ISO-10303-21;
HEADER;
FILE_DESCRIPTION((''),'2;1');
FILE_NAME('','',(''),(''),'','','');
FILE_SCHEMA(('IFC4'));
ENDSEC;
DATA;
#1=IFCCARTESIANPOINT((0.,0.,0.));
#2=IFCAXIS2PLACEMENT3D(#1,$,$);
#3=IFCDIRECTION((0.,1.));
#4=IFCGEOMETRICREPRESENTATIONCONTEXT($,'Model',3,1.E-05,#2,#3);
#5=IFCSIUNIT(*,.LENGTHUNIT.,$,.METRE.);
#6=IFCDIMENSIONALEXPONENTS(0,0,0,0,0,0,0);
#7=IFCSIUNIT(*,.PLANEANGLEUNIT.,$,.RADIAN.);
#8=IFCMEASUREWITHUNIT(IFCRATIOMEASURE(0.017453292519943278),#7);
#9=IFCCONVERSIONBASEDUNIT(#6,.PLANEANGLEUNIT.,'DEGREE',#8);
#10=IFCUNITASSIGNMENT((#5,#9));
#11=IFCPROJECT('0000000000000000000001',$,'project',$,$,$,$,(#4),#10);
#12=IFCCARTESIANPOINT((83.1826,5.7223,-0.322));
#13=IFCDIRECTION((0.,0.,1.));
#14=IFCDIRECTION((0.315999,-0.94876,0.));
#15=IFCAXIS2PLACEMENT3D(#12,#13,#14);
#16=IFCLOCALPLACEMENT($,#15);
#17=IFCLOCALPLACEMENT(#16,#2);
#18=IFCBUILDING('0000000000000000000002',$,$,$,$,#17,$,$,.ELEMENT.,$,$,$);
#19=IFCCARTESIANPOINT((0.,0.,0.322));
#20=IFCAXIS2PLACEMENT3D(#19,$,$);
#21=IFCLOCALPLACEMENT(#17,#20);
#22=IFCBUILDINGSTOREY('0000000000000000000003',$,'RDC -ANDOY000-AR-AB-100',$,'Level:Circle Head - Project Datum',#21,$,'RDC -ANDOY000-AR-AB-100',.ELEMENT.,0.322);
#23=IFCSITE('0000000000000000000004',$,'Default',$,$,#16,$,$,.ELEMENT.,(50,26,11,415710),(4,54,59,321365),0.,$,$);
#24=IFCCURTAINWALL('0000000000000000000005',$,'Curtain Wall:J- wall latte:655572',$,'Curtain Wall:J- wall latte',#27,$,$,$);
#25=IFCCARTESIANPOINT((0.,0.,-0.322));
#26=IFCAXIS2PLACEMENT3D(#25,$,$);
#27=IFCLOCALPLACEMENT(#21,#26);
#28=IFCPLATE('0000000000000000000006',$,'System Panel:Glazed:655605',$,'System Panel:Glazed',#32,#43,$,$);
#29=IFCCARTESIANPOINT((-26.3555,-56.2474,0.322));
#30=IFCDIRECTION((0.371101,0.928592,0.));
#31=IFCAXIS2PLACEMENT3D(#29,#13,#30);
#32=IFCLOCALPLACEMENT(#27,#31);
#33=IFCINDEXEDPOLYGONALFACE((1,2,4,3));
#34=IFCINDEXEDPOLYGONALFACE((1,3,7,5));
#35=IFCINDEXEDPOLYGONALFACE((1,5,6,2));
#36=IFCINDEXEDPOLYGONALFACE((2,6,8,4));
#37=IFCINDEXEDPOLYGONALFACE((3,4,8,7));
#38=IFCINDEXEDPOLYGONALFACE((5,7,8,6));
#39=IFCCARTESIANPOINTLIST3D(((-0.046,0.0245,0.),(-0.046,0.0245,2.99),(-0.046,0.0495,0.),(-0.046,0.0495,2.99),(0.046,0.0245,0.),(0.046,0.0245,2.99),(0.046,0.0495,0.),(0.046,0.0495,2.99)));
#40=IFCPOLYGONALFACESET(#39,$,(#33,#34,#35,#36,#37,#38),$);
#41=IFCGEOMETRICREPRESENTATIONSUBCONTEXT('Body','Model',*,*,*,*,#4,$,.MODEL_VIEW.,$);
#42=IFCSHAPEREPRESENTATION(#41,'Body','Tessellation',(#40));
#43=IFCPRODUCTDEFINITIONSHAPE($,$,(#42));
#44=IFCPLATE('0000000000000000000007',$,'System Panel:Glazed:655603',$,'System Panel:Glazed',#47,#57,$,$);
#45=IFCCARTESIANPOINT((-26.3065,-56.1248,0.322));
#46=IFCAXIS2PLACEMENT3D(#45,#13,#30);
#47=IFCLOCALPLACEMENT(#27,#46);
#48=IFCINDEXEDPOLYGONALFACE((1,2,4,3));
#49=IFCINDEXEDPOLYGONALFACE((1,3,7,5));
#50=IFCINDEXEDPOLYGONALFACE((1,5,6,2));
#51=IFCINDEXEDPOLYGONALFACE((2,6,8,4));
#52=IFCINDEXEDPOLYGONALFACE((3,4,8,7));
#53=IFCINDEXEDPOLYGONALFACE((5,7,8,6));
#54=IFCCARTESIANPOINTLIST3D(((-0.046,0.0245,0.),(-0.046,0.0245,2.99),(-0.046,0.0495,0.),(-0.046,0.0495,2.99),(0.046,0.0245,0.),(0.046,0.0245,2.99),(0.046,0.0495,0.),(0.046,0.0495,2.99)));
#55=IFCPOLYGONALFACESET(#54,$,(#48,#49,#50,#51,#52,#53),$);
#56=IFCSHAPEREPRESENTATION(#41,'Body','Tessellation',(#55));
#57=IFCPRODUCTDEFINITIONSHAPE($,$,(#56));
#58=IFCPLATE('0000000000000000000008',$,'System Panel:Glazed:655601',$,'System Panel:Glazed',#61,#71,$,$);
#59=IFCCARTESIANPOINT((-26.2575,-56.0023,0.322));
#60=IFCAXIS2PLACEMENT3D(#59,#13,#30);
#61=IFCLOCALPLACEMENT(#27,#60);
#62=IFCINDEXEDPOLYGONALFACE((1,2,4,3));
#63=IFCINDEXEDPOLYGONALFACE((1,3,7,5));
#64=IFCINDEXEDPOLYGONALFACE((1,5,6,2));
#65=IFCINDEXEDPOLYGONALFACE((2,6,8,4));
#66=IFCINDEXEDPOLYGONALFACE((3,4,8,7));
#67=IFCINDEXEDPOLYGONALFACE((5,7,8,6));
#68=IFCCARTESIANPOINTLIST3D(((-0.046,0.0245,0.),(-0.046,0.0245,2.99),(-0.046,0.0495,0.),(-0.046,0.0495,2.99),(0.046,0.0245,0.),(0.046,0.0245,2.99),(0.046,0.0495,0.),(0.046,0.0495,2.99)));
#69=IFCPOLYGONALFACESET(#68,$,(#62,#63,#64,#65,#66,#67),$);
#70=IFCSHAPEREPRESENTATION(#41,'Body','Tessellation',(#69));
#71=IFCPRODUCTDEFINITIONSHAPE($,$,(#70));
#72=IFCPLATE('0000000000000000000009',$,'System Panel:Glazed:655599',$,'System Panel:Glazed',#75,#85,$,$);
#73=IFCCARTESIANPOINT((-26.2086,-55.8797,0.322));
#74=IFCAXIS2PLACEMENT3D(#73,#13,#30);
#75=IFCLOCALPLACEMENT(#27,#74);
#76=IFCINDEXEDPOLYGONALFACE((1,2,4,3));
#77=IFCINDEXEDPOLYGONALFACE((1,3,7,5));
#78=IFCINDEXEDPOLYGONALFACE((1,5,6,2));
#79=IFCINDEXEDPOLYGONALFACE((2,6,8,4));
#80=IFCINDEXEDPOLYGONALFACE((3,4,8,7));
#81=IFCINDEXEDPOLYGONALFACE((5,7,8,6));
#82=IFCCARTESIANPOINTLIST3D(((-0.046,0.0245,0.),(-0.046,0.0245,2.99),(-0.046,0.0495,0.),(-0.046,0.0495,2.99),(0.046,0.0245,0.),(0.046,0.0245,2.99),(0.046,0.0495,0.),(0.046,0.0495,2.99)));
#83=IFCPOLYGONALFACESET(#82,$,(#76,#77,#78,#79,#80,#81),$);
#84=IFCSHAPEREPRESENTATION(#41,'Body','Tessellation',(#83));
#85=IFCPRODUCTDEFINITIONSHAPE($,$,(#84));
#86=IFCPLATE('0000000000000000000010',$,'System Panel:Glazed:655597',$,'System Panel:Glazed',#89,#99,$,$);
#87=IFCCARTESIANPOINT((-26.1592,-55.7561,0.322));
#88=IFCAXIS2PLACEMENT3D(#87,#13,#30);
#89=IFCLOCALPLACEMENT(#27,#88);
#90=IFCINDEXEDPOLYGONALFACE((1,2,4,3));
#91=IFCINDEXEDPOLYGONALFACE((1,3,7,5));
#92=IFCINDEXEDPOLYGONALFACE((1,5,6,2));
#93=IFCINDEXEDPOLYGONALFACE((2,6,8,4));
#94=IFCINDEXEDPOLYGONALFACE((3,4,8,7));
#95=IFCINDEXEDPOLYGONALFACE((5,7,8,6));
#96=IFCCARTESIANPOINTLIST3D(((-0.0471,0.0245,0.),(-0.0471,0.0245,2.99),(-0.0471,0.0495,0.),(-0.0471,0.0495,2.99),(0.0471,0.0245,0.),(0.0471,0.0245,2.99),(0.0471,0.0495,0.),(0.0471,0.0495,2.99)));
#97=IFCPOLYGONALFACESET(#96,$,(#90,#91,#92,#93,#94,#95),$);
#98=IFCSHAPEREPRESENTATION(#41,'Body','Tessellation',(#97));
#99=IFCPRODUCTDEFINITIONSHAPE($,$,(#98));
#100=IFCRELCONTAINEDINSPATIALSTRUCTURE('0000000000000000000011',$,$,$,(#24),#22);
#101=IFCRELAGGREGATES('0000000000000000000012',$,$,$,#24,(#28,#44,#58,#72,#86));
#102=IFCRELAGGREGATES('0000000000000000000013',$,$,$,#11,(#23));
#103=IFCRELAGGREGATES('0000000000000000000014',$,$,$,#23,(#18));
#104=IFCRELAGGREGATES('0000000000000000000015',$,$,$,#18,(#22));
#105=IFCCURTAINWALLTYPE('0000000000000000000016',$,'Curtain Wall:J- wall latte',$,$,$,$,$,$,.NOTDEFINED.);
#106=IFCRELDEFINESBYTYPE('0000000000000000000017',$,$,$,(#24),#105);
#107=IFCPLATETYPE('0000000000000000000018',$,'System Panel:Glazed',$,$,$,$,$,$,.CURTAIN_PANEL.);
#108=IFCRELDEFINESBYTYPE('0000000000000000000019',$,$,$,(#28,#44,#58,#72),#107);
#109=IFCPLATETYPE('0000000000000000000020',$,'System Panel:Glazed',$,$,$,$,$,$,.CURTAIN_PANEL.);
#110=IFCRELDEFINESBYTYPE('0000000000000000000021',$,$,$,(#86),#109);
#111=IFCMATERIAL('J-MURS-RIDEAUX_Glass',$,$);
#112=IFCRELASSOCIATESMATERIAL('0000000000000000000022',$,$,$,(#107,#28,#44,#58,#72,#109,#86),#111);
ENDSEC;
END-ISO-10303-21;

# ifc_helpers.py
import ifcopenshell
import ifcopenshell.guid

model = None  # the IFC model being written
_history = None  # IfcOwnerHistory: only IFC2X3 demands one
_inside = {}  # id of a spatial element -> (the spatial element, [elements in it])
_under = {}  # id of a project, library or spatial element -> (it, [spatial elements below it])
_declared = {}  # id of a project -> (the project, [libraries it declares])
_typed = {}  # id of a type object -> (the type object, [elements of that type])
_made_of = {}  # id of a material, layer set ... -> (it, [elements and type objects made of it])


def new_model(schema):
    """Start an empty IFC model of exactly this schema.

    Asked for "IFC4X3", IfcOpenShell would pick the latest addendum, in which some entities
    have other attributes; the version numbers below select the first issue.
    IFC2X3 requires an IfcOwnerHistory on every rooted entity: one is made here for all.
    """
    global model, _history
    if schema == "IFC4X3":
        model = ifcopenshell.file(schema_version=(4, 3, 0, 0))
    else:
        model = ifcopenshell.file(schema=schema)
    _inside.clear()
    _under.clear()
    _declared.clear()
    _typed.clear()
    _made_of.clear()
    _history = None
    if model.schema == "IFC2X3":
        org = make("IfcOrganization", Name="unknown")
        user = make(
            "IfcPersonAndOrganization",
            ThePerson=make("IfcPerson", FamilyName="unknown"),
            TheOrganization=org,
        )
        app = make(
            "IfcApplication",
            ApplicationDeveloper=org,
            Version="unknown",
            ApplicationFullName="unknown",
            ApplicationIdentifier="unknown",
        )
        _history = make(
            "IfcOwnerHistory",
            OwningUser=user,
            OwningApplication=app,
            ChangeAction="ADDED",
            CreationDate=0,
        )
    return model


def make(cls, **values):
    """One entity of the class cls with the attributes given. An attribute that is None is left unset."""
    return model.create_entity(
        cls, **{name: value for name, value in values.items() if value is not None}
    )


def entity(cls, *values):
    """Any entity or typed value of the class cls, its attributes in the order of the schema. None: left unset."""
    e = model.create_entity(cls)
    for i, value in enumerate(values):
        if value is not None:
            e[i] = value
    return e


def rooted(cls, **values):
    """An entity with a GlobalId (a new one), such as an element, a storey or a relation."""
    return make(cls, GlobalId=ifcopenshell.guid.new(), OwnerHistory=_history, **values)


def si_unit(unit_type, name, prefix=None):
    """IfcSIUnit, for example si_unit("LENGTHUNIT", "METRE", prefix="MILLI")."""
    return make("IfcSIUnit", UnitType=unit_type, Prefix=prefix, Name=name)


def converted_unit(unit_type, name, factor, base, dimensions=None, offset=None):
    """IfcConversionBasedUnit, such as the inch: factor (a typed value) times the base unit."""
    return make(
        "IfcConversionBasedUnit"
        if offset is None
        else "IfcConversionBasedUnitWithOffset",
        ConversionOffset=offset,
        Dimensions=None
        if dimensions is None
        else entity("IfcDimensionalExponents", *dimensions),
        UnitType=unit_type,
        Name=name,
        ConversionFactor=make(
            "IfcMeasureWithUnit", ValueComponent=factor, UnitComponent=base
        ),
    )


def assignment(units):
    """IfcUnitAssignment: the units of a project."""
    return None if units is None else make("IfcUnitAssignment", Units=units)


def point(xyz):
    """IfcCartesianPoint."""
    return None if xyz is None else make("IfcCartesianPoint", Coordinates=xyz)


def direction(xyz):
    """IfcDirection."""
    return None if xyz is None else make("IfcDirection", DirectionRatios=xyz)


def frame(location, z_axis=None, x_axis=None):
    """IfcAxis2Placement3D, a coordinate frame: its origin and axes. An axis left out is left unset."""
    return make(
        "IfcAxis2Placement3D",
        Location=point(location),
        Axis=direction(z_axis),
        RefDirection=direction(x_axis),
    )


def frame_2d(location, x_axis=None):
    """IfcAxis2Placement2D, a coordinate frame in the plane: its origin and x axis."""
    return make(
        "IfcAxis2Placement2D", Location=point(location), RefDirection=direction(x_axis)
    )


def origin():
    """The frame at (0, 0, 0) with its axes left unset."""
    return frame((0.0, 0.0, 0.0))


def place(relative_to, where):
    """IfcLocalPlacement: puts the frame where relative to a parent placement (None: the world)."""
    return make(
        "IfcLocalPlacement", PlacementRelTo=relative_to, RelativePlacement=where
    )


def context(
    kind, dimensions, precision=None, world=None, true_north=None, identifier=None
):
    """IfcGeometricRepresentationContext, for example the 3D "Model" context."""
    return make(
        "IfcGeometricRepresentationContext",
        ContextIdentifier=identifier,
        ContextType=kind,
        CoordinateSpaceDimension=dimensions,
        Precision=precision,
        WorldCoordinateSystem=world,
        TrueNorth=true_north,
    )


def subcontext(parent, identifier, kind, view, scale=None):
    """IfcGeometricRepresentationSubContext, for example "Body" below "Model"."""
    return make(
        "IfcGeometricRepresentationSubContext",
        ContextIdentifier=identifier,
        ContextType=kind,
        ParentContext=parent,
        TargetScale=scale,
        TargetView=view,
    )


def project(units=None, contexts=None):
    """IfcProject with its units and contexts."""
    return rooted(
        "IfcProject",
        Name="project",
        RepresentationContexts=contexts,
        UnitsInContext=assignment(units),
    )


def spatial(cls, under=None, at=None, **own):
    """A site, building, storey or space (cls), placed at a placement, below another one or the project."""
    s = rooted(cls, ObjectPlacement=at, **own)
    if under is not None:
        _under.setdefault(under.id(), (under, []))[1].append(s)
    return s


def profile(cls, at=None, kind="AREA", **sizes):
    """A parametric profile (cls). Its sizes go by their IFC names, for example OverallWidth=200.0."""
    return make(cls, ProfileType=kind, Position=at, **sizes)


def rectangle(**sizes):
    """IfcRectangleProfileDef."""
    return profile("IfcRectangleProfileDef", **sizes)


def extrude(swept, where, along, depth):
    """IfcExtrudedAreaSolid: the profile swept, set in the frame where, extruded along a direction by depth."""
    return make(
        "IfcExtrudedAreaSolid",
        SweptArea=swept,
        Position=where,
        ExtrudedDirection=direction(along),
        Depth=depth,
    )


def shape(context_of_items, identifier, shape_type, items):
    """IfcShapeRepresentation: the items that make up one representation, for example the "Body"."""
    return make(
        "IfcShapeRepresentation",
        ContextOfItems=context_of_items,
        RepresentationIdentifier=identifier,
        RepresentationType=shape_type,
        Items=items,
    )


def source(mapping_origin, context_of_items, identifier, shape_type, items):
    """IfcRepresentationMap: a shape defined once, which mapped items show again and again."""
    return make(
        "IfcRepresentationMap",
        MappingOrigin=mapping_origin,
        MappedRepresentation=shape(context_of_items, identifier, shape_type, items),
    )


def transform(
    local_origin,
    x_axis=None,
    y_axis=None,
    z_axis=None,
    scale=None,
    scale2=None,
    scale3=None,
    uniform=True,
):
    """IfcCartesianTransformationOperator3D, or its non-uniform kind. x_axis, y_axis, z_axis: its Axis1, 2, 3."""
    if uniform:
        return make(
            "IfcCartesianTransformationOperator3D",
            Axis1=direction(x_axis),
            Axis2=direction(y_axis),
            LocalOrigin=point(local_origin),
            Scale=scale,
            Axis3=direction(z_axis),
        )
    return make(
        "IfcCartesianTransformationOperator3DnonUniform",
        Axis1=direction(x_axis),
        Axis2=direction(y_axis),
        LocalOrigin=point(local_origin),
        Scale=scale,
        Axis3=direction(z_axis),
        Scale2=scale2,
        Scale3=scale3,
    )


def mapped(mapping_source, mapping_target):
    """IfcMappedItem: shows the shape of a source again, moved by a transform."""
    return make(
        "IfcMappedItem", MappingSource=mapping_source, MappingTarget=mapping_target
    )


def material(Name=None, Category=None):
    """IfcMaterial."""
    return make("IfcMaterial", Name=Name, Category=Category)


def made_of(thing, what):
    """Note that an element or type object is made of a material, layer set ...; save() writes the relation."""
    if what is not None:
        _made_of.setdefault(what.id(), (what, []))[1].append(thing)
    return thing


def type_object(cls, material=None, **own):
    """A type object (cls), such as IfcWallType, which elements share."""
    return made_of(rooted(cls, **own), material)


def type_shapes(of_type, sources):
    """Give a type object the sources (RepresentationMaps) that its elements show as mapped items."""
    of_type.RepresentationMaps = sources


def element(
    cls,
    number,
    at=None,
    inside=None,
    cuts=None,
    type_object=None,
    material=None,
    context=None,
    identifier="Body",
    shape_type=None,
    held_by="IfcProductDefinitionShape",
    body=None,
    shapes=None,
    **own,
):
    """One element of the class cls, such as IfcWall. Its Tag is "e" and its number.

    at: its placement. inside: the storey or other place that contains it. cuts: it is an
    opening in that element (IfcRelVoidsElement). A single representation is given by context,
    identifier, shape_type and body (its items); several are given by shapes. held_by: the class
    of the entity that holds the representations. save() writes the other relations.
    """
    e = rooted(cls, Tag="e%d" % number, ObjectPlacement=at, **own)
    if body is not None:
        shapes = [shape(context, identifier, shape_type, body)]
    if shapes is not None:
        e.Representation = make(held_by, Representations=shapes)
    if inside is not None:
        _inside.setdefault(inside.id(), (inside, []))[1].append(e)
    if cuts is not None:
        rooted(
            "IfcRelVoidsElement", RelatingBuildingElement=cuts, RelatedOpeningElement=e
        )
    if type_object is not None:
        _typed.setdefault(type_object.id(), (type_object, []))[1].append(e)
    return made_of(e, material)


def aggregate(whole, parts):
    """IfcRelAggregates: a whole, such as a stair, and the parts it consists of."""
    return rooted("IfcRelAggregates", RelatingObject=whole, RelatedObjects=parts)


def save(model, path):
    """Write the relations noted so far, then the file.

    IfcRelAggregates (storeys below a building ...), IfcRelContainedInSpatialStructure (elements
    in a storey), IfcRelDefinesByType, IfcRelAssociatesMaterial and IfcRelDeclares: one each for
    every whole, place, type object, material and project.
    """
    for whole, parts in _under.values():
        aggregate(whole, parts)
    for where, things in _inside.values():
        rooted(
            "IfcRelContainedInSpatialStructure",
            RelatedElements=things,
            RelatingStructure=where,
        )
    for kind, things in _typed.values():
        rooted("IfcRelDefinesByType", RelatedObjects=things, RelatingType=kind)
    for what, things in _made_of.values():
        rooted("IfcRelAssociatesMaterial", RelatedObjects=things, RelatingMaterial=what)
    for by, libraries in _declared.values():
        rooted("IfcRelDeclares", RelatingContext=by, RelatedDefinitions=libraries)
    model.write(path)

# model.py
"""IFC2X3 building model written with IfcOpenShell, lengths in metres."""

from ifc_helpers import new_model, entity, si_unit, converted_unit, direction, frame, frame_2d, origin, place, context, subcontext, project, spatial, rectangle, extrude, source, transform, mapped, material, type_object, type_shapes, element, aggregate, save


model = new_model("IFC2X3")

# Units and contexts
model_context = context("Model", 3, precision=1e-05, world=origin(), true_north=direction((0.0, 1.0)))
body_context = subcontext(model_context, "Body", "Model", "MODEL_VIEW")
ifc_project = project(units=[si_unit("LENGTHUNIT", "METRE"), converted_unit("PLANEANGLEUNIT", "DEGREE", entity("IfcRatioMeasure", 0.017453292519943278), si_unit("PLANEANGLEUNIT", "RADIAN"), dimensions=[0, 0, 0, 0, 0, 0, 0])], contexts=[model_context])

# Site, building, storey
site_placement = place(None, frame((83.1826, 5.7223, -0.322), z_axis=(0.0, 0.0, 1.0), x_axis=(0.315999, -0.94876, 0.0)))
site = spatial("IfcSite", under=ifc_project, at=site_placement, Name="Default", CompositionType="ELEMENT", RefLatitude=(50, 26, 11, 415710), RefLongitude=(4, 54, 59, 321365), RefElevation=0.0)
building_placement = place(site_placement, origin())
building = spatial("IfcBuilding", under=site, at=building_placement, CompositionType="ELEMENT")
storey_placement = place(building_placement, frame((0.0, 0.0, 0.322)))
storey = spatial("IfcBuildingStorey", under=building, at=storey_placement, Name="RDC -ANDOY000-AR-AB-100", ObjectType="Level:Circle Head - Project Datum", LongName="RDC -ANDOY000-AR-AB-100", CompositionType="ELEMENT", Elevation=0.322)

# Curtain wall, plates
curtain_wall_type = type_object("IfcCurtainWallType", Name="Curtain Wall:J- wall latte", PredefinedType="NOTDEFINED")
curtain_wall_placement = place(storey_placement, frame((0.0, 0.0, -0.322)))
curtain_wall = element("IfcCurtainWall", 1, at=curtain_wall_placement, inside=storey, type_object=curtain_wall_type, Name="Curtain Wall:J- wall latte:655572", ObjectType="Curtain Wall:J- wall latte")
ifc_material_1 = material(Name="J-MURS-RIDEAUX_Glass")
plate_type_1 = type_object("IfcPlateType", Name="System Panel:Glazed", PredefinedType="CURTAIN_PANEL", material=ifc_material_1)
shared_shape_1 = source(origin(), body_context, "Body", "SweptSolid", [
    extrude(rectangle(XDim=0.025, YDim=0.092, at=frame_2d((0.0, 0.0), x_axis=(1.0, 0.0))), frame((0.0, 0.037, 0.0), z_axis=(0.0, 0.0, 1.0), x_axis=(0.0, 1.0, 0.0)), (0.0, 0.0, 1.0), 2.99),
])
type_shapes(plate_type_1, [shared_shape_1])
plate_1_placement = place(curtain_wall_placement, frame((-26.3555, -56.2474, 0.322), z_axis=(0.0, 0.0, 1.0), x_axis=(0.371101, 0.928592, 0.0)))
plate_1 = element("IfcPlate", 2, at=plate_1_placement, type_object=plate_type_1, material=ifc_material_1, Name="System Panel:Glazed:655605", ObjectType="System Panel:Glazed", context=body_context, shape_type="MappedRepresentation", body=[
    mapped(shared_shape_1, transform((0.0, 0.0, 0.0), scale=1.0)),
])
plate_2_placement = place(curtain_wall_placement, frame((-26.3065, -56.1248, 0.322), z_axis=(0.0, 0.0, 1.0), x_axis=(0.371101, 0.928592, 0.0)))
plate_2 = element("IfcPlate", 3, at=plate_2_placement, type_object=plate_type_1, material=ifc_material_1, Name="System Panel:Glazed:655603", ObjectType="System Panel:Glazed", context=body_context, shape_type="MappedRepresentation", body=[
    mapped(shared_shape_1, transform((0.0, 0.0, 0.0), scale=1.0)),
])
plate_3_placement = place(curtain_wall_placement, frame((-26.2575, -56.0023, 0.322), z_axis=(0.0, 0.0, 1.0), x_axis=(0.371101, 0.928592, 0.0)))
plate_3 = element("IfcPlate", 4, at=plate_3_placement, type_object=plate_type_1, material=ifc_material_1, Name="System Panel:Glazed:655601", ObjectType="System Panel:Glazed", context=body_context, shape_type="MappedRepresentation", body=[
    mapped(shared_shape_1, transform((0.0, 0.0, 0.0), scale=1.0)),
])
plate_4_placement = place(curtain_wall_placement, frame((-26.2086, -55.8797, 0.322), z_axis=(0.0, 0.0, 1.0), x_axis=(0.371101, 0.928592, 0.0)))
plate_4 = element("IfcPlate", 5, at=plate_4_placement, type_object=plate_type_1, material=ifc_material_1, Name="System Panel:Glazed:655599", ObjectType="System Panel:Glazed", context=body_context, shape_type="MappedRepresentation", body=[
    mapped(shared_shape_1, transform((0.0, 0.0, 0.0), scale=1.0)),
])
plate_type_2 = type_object("IfcPlateType", Name="System Panel:Glazed", PredefinedType="CURTAIN_PANEL", material=ifc_material_1)
shared_shape_2 = source(origin(), body_context, "Body", "SweptSolid", [
    extrude(rectangle(XDim=0.025, YDim=0.0942, at=frame_2d((0.0, 0.0), x_axis=(1.0, 0.0))), frame((0.0, 0.037, 0.0), z_axis=(0.0, 0.0, 1.0), x_axis=(0.0, 1.0, 0.0)), (0.0, 0.0, 1.0), 2.99),
])
type_shapes(plate_type_2, [shared_shape_2])
plate_5_placement = place(curtain_wall_placement, frame((-26.1592, -55.7561, 0.322), z_axis=(0.0, 0.0, 1.0), x_axis=(0.371101, 0.928592, 0.0)))
plate_5 = element("IfcPlate", 6, at=plate_5_placement, type_object=plate_type_2, material=ifc_material_1, Name="System Panel:Glazed:655597", ObjectType="System Panel:Glazed", context=body_context, shape_type="MappedRepresentation", body=[
    mapped(shared_shape_2, transform((0.0, 0.0, 0.0), scale=1.0)),
])
aggregate(curtain_wall, [plate_1, plate_2, plate_3, plate_4, plate_5])

save(model, "model.ifc")
